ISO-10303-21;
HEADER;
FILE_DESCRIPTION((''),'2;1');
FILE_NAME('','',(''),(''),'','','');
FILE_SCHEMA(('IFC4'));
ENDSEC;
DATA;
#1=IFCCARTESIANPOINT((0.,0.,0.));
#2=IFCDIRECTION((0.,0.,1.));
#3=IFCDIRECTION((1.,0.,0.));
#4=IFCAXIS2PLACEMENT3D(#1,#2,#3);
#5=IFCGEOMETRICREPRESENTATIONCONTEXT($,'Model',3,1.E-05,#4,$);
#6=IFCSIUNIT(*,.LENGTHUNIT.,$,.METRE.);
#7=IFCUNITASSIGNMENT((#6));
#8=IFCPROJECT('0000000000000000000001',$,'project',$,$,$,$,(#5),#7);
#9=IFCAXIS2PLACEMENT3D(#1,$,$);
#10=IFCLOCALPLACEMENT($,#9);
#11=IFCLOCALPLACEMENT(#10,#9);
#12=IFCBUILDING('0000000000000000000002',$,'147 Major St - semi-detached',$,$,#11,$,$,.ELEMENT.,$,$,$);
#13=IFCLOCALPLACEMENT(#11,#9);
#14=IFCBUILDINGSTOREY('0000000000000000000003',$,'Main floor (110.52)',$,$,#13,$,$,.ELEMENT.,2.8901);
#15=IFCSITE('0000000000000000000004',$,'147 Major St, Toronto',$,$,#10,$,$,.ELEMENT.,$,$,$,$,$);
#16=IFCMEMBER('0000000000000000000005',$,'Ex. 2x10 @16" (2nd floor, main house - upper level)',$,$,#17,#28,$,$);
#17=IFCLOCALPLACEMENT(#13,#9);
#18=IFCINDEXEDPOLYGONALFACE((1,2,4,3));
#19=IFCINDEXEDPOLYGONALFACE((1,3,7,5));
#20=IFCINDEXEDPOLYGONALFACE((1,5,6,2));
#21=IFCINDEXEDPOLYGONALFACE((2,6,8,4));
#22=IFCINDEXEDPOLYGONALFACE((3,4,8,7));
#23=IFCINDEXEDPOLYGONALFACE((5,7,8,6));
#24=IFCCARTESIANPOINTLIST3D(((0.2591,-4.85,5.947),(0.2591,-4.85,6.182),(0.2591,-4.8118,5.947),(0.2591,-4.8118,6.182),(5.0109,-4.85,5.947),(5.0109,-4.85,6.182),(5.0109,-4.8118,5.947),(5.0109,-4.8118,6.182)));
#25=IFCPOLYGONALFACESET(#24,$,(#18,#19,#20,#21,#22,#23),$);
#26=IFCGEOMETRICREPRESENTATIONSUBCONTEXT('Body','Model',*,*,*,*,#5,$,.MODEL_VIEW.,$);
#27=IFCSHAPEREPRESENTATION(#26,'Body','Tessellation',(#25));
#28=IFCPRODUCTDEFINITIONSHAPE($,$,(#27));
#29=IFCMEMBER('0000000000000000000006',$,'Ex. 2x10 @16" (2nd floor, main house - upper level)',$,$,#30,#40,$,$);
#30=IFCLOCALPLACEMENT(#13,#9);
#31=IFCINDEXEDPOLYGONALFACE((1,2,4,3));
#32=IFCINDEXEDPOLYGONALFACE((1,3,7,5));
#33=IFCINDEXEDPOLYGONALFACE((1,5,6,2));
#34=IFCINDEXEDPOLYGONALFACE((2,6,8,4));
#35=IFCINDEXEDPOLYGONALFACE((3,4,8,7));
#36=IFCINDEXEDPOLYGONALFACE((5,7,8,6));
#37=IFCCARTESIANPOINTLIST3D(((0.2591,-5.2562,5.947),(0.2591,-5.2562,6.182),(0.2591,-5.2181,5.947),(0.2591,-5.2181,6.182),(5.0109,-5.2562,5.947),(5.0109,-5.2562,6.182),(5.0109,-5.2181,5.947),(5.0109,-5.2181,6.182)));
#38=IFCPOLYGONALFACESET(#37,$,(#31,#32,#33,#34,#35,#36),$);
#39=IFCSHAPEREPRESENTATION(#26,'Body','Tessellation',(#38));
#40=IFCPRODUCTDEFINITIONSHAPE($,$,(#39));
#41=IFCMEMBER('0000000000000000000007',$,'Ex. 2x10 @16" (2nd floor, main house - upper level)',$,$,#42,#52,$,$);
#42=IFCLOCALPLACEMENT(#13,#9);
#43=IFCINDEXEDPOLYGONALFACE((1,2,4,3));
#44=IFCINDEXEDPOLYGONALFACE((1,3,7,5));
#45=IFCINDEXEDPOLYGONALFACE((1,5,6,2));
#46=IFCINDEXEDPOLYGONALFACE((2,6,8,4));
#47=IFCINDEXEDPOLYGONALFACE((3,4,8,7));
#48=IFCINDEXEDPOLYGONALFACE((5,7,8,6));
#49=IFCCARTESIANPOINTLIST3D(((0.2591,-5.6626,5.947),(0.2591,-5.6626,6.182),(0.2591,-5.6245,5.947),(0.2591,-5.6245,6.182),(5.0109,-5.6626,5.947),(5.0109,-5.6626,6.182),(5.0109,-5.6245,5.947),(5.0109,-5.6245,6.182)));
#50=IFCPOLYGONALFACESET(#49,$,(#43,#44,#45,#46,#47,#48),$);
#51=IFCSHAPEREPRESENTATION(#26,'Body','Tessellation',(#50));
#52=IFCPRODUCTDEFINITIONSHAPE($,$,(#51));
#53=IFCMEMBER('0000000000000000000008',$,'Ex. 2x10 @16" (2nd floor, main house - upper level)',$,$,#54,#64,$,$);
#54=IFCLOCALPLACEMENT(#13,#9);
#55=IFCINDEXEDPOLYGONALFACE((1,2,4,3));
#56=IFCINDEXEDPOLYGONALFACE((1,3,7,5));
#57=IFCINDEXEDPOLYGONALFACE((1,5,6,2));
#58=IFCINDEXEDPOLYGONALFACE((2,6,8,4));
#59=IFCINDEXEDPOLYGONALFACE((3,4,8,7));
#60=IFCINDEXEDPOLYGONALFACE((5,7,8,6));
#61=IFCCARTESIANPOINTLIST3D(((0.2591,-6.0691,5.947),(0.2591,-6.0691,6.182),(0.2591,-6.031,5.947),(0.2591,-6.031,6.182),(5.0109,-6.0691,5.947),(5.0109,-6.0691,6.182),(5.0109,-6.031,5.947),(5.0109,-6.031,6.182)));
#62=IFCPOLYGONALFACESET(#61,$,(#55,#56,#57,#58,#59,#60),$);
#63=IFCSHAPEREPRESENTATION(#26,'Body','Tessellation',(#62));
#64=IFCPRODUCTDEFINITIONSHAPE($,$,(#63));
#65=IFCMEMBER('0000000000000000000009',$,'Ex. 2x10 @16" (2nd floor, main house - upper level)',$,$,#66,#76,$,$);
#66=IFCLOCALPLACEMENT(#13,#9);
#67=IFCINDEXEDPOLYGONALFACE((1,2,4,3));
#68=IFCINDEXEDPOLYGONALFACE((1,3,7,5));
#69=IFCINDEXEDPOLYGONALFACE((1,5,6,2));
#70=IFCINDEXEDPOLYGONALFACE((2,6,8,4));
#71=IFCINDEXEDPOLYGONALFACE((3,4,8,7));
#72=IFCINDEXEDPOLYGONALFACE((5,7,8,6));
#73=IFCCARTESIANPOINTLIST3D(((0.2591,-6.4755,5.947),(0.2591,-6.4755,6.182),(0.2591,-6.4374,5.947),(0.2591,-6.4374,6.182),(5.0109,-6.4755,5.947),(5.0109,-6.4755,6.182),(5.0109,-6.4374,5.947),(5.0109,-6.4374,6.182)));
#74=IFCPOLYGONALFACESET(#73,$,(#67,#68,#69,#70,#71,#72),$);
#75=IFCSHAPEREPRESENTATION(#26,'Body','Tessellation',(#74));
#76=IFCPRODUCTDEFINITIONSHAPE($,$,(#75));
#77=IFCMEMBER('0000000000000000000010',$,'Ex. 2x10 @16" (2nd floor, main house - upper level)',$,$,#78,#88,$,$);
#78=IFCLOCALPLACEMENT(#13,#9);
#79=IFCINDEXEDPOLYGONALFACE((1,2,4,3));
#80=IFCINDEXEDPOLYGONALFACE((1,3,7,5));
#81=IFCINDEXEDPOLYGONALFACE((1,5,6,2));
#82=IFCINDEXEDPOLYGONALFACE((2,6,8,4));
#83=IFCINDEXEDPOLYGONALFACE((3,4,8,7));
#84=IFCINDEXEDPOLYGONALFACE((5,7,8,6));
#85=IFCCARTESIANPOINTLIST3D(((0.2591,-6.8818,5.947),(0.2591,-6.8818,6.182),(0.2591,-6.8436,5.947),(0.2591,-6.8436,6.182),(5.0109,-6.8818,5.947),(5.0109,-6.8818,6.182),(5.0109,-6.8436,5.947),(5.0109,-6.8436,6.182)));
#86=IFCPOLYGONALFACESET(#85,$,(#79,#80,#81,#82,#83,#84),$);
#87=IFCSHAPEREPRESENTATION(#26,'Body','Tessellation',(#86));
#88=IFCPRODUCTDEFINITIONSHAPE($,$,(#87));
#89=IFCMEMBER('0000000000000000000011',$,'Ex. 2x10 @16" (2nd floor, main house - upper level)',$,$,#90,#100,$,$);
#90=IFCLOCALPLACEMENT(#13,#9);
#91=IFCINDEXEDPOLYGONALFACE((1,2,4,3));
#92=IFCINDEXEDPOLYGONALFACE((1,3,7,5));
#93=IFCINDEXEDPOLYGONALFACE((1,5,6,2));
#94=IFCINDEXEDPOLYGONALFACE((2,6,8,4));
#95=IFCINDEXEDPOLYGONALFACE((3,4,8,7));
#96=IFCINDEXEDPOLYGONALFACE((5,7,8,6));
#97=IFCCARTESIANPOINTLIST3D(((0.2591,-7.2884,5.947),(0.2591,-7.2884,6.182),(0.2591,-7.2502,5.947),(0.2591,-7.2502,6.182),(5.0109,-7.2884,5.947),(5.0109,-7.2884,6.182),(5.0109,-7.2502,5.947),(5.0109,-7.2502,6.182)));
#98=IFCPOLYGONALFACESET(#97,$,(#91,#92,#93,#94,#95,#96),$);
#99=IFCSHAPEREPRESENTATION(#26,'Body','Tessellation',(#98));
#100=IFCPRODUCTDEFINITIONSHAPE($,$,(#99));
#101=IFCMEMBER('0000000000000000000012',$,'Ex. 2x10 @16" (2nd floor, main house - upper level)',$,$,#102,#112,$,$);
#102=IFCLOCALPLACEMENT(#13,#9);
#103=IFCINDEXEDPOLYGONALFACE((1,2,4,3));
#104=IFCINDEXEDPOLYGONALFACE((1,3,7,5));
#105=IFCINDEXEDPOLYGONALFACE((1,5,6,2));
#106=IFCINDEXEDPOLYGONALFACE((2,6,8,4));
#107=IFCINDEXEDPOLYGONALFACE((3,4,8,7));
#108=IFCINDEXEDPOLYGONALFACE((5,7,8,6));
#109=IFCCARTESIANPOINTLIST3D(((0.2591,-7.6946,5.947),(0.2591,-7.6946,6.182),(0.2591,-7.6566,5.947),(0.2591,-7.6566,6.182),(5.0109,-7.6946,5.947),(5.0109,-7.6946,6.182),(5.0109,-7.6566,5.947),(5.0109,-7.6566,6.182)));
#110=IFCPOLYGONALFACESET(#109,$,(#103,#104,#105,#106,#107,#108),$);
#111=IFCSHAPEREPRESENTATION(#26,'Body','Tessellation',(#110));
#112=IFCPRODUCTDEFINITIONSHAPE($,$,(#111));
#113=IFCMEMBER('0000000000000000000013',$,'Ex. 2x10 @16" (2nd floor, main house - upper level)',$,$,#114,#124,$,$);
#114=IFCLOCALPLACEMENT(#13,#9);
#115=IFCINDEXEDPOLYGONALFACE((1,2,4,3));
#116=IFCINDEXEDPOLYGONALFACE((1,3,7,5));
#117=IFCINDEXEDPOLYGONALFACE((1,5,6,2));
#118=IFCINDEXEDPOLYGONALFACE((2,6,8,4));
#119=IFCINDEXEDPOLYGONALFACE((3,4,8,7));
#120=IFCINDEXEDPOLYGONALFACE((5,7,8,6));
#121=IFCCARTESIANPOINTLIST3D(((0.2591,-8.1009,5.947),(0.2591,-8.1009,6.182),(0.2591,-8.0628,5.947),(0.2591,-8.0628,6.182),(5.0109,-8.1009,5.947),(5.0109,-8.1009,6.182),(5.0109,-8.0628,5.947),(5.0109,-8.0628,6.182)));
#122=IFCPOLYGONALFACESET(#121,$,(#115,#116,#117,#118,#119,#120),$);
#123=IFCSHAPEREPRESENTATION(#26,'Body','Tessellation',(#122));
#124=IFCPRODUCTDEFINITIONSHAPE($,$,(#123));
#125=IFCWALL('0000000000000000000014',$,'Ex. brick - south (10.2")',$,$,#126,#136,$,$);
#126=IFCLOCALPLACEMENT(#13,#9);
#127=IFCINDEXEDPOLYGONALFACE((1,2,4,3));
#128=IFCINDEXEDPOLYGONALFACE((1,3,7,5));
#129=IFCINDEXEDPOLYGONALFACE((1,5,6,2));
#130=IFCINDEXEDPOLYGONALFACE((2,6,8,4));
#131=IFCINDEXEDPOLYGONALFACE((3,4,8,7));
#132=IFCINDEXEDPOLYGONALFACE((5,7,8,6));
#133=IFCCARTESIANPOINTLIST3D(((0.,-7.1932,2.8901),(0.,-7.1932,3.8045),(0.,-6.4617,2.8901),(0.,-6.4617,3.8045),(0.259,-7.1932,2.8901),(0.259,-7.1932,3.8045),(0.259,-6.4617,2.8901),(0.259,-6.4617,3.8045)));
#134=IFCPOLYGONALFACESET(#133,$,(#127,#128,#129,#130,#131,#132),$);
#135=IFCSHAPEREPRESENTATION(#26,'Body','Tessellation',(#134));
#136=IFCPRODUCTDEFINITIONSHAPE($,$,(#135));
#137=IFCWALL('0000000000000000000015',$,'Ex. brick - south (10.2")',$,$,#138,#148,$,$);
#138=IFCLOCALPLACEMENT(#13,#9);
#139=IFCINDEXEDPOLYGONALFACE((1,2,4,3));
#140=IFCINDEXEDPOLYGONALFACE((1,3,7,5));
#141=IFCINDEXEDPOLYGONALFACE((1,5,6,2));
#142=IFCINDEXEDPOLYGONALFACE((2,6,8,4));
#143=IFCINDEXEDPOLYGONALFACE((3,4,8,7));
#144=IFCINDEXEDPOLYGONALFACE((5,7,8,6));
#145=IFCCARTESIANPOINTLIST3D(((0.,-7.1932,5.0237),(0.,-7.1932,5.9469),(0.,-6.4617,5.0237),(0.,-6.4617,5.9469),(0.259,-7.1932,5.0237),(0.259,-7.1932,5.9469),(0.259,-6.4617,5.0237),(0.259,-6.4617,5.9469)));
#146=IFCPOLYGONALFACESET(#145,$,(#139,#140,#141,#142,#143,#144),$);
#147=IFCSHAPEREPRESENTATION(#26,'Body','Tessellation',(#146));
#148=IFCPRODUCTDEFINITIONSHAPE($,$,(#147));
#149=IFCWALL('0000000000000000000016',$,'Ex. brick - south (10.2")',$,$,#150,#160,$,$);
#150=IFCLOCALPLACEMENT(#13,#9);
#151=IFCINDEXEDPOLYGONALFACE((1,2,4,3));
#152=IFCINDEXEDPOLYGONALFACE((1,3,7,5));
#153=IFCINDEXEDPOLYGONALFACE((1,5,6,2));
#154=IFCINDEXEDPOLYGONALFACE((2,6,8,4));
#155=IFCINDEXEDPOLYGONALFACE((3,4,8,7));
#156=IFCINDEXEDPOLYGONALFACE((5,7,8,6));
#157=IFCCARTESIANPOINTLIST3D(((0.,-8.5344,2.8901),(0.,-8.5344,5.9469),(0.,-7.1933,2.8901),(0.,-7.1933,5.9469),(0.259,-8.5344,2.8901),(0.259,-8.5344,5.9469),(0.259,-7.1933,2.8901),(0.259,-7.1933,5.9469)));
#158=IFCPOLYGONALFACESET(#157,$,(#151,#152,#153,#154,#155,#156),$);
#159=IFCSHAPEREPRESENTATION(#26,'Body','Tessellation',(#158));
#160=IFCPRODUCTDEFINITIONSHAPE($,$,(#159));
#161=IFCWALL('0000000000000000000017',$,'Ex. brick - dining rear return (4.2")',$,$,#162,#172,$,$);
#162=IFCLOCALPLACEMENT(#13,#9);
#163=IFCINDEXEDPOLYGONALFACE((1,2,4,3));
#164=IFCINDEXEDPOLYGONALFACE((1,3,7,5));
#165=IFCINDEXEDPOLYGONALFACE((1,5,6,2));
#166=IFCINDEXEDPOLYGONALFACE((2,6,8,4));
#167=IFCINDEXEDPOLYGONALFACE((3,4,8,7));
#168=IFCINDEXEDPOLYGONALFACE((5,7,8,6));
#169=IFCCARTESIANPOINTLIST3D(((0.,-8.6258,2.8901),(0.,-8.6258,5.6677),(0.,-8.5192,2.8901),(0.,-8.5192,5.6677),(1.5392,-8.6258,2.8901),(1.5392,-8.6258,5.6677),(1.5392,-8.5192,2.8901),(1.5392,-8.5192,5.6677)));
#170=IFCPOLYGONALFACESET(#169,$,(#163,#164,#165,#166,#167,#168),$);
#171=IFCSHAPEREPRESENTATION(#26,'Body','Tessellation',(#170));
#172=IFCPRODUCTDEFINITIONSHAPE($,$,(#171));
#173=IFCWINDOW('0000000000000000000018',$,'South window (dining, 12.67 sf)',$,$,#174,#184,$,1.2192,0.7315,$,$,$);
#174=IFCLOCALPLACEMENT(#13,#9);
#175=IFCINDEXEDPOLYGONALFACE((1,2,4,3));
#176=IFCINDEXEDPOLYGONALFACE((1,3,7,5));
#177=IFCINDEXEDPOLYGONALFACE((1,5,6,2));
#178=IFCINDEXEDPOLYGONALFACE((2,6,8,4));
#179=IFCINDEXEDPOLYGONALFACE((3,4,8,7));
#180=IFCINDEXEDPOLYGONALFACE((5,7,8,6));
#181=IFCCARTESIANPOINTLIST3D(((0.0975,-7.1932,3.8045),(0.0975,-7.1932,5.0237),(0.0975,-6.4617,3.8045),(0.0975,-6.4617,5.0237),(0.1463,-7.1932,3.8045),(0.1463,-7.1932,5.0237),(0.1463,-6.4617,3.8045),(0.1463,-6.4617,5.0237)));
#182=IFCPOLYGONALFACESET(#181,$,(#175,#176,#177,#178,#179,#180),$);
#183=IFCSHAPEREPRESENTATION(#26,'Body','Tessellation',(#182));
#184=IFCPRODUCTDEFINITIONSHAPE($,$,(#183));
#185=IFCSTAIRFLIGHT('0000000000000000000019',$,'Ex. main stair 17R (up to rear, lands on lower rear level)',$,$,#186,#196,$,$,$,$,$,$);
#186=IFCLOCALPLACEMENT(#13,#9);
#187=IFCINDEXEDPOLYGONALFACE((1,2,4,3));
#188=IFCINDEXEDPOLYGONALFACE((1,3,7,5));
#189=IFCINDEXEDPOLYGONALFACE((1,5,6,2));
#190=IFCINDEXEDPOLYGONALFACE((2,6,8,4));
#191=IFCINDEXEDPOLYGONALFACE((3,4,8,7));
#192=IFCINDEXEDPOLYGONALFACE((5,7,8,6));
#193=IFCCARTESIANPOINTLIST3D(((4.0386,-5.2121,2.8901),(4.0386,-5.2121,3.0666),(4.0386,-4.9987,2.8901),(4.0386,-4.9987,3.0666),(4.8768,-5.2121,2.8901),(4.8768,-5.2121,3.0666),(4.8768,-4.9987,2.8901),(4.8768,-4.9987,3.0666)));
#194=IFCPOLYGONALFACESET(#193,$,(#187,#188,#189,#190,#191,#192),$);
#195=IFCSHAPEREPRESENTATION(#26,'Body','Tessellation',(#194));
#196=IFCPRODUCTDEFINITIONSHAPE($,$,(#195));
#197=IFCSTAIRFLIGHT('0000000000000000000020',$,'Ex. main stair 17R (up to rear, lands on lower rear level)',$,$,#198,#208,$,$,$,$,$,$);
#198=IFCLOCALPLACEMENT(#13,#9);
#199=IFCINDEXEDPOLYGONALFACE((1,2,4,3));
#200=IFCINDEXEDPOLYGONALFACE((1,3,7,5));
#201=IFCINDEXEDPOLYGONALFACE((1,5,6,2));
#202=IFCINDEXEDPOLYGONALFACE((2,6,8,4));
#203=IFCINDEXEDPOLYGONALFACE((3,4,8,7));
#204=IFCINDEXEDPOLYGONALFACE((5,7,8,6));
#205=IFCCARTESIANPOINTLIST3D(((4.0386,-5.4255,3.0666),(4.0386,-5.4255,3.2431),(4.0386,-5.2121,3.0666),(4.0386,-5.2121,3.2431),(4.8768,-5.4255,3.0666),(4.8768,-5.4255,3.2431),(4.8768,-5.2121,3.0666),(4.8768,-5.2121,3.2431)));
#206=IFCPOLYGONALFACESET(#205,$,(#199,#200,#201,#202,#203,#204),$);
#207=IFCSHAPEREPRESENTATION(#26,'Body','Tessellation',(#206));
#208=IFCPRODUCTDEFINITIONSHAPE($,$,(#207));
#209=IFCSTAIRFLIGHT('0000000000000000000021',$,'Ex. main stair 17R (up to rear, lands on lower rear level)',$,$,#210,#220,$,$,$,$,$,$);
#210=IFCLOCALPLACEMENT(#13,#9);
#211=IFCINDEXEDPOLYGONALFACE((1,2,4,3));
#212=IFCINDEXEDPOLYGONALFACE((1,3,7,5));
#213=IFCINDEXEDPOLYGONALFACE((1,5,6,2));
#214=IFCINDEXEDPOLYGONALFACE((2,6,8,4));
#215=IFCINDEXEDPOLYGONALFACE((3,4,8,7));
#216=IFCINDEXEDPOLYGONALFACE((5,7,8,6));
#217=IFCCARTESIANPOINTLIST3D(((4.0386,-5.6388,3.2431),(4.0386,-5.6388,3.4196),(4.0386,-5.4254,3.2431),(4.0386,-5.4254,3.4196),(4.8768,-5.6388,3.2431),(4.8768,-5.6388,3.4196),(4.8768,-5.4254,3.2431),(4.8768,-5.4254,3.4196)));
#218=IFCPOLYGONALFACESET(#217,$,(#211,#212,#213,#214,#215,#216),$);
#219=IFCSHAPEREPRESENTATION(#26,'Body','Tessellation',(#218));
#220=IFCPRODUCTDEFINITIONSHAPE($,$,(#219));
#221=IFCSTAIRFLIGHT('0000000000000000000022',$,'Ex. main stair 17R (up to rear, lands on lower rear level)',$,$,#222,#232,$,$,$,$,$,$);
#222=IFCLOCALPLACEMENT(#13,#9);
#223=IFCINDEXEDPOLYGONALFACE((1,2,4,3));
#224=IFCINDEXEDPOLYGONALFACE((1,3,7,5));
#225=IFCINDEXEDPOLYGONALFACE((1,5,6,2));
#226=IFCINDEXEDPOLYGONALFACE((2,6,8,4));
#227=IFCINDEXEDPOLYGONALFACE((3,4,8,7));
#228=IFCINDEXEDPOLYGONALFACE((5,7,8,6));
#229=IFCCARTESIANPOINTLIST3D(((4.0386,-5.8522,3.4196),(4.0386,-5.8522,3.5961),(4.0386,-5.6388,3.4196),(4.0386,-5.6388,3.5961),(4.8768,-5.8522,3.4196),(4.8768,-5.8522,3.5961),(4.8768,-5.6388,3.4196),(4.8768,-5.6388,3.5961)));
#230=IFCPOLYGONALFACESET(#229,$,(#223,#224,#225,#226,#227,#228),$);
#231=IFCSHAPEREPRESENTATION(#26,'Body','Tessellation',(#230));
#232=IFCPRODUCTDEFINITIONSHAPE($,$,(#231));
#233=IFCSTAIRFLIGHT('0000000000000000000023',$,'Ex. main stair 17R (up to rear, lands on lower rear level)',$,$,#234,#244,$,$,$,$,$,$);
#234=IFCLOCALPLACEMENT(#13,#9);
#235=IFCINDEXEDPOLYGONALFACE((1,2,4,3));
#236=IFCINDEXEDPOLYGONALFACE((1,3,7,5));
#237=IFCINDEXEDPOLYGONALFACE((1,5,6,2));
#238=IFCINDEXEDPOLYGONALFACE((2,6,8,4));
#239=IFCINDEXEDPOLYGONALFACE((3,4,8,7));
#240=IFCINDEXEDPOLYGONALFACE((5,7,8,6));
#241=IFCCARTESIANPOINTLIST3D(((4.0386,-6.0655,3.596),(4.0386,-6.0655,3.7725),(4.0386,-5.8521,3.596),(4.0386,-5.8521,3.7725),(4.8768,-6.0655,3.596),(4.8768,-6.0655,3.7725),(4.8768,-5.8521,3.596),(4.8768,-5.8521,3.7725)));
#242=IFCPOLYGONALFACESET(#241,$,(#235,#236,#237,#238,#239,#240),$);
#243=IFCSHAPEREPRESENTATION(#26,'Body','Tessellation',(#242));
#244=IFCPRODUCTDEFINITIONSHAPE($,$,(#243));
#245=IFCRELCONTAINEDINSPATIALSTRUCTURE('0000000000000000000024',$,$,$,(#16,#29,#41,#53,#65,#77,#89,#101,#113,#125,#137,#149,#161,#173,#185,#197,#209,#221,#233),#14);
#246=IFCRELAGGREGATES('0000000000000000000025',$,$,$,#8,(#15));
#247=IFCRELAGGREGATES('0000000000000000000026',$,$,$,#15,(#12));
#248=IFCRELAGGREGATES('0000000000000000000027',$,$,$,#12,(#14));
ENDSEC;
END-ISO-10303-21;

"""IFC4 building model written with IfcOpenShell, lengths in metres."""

from ifc_helpers import new_model, si_unit, frame, origin, origin_with_axes, place, context, subcontext, project, spatial, rectangle, extrude, element, save


model = new_model("IFC4")

# Units and contexts
model_context = context("Model", 3, precision=1e-05, world=origin_with_axes())
body_context = subcontext(model_context, "Body", "Model", "MODEL_VIEW")
ifc_project = project(units=[si_unit("LENGTHUNIT", "METRE")], contexts=[model_context])

# Site, building, storey
site_placement = place(None, origin())
site = spatial("IfcSite", under=ifc_project, at=site_placement, Name="147 Major St, Toronto", CompositionType="ELEMENT")
building_placement = place(site_placement, origin())
building = spatial("IfcBuilding", under=site, at=building_placement, Name="147 Major St - semi-detached", CompositionType="ELEMENT")
storey_placement = place(building_placement, origin())
storey = spatial("IfcBuildingStorey", under=building, at=storey_placement, Name="Main floor (110.52)", CompositionType="ELEMENT", Elevation=2.8901)

# Members
for number, where, name in (
    (1, (2.635, -4.8309, 5.947), "Ex. 2x10 @16\" (2nd floor, main house - upper level)"),
    (2, (2.635, -5.2372, 5.947), "Ex. 2x10 @16\" (2nd floor, main house - upper level)"),
    (3, (2.635, -5.6435, 5.947), "Ex. 2x10 @16\" (2nd floor, main house - upper level)"),
    (4, (2.635, -6.0501, 5.947), "Ex. 2x10 @16\" (2nd floor, main house - upper level)"),
    (5, (2.635, -6.4564, 5.947), "Ex. 2x10 @16\" (2nd floor, main house - upper level)"),
    (6, (2.635, -6.8627, 5.947), "Ex. 2x10 @16\" (2nd floor, main house - upper level)"),
    (7, (2.635, -7.2693, 5.947), "Ex. 2x10 @16\" (2nd floor, main house - upper level)"),
    (8, (2.635, -7.6756, 5.947), "Ex. 2x10 @16\" (2nd floor, main house - upper level)"),
    (9, (2.635, -8.0819, 5.947), "Ex. 2x10 @16\" (2nd floor, main house - upper level)"),
):
    element("IfcMember", number, at=place(storey_placement, frame(where)), inside=storey, Name=name, context=body_context, shape_type="SweptSolid", body=[
        extrude(rectangle(XDim=4.7518, YDim=0.0381), origin_with_axes(), (0.0, 0.0, 1.0), 0.235),
    ])

# Walls
wall_1_placement = place(storey_placement, frame((0.1295, -6.8275, 2.8901)))
element("IfcWall", 10, at=wall_1_placement, inside=storey, Name="Ex. brick - south (10.2\")", context=body_context, shape_type="SweptSolid", body=[
    extrude(rectangle(XDim=0.2591, YDim=0.7315), origin_with_axes(), (0.0, 0.0, 1.0), 0.9144),
])
wall_2_placement = place(storey_placement, frame((0.1295, -6.8275, 5.0237)))
element("IfcWall", 11, at=wall_2_placement, inside=storey, Name="Ex. brick - south (10.2\")", context=body_context, shape_type="SweptSolid", body=[
    extrude(rectangle(XDim=0.2591, YDim=0.7315), origin_with_axes(), (0.0, 0.0, 1.0), 0.9232),
])
wall_3_placement = place(storey_placement, frame((0.1295, -7.8638, 2.8901)))
element("IfcWall", 12, at=wall_3_placement, inside=storey, Name="Ex. brick - south (10.2\")", context=body_context, shape_type="SweptSolid", body=[
    extrude(rectangle(XDim=0.2591, YDim=1.3411), origin_with_axes(), (0.0, 0.0, 1.0), 3.0568),
])
wall_4_placement = place(storey_placement, frame((0.7696, -8.5725, 2.8901)))
element("IfcWall", 13, at=wall_4_placement, inside=storey, Name="Ex. brick - dining rear return (4.2\")", context=body_context, shape_type="SweptSolid", body=[
    extrude(rectangle(XDim=1.5392, YDim=0.1067), origin_with_axes(), (0.0, 0.0, 1.0), 2.7776),
])

# Window
window_placement = place(storey_placement, frame((0.1219, -6.8275, 3.8045)))
element("IfcWindow", 14, at=window_placement, inside=storey, Name="South window (dining, 12.67 sf)", OverallHeight=1.2192, OverallWidth=0.7315, context=body_context, shape_type="SweptSolid", body=[
    extrude(rectangle(XDim=0.0488, YDim=0.7315), origin_with_axes(), (0.0, 0.0, 1.0), 1.2192),
])

# Stair flights
for number, where, name in (
    (15, (4.4577, -5.1054, 2.8901), "Ex. main stair 17R (up to rear, lands on lower rear level)"),
    (16, (4.4577, -5.3188, 3.0666), "Ex. main stair 17R (up to rear, lands on lower rear level)"),
    (17, (4.4577, -5.5321, 3.2431), "Ex. main stair 17R (up to rear, lands on lower rear level)"),
    (18, (4.4577, -5.7455, 3.4196), "Ex. main stair 17R (up to rear, lands on lower rear level)"),
    (19, (4.4577, -5.9588, 3.596), "Ex. main stair 17R (up to rear, lands on lower rear level)"),
):
    element("IfcStairFlight", number, at=place(storey_placement, frame(where)), inside=storey, Name=name, context=body_context, shape_type="SweptSolid", body=[
        extrude(rectangle(XDim=0.8382, YDim=0.2134), origin_with_axes(), (0.0, 0.0, 1.0), 0.1765),
    ])

save(model, "model.ifc")
